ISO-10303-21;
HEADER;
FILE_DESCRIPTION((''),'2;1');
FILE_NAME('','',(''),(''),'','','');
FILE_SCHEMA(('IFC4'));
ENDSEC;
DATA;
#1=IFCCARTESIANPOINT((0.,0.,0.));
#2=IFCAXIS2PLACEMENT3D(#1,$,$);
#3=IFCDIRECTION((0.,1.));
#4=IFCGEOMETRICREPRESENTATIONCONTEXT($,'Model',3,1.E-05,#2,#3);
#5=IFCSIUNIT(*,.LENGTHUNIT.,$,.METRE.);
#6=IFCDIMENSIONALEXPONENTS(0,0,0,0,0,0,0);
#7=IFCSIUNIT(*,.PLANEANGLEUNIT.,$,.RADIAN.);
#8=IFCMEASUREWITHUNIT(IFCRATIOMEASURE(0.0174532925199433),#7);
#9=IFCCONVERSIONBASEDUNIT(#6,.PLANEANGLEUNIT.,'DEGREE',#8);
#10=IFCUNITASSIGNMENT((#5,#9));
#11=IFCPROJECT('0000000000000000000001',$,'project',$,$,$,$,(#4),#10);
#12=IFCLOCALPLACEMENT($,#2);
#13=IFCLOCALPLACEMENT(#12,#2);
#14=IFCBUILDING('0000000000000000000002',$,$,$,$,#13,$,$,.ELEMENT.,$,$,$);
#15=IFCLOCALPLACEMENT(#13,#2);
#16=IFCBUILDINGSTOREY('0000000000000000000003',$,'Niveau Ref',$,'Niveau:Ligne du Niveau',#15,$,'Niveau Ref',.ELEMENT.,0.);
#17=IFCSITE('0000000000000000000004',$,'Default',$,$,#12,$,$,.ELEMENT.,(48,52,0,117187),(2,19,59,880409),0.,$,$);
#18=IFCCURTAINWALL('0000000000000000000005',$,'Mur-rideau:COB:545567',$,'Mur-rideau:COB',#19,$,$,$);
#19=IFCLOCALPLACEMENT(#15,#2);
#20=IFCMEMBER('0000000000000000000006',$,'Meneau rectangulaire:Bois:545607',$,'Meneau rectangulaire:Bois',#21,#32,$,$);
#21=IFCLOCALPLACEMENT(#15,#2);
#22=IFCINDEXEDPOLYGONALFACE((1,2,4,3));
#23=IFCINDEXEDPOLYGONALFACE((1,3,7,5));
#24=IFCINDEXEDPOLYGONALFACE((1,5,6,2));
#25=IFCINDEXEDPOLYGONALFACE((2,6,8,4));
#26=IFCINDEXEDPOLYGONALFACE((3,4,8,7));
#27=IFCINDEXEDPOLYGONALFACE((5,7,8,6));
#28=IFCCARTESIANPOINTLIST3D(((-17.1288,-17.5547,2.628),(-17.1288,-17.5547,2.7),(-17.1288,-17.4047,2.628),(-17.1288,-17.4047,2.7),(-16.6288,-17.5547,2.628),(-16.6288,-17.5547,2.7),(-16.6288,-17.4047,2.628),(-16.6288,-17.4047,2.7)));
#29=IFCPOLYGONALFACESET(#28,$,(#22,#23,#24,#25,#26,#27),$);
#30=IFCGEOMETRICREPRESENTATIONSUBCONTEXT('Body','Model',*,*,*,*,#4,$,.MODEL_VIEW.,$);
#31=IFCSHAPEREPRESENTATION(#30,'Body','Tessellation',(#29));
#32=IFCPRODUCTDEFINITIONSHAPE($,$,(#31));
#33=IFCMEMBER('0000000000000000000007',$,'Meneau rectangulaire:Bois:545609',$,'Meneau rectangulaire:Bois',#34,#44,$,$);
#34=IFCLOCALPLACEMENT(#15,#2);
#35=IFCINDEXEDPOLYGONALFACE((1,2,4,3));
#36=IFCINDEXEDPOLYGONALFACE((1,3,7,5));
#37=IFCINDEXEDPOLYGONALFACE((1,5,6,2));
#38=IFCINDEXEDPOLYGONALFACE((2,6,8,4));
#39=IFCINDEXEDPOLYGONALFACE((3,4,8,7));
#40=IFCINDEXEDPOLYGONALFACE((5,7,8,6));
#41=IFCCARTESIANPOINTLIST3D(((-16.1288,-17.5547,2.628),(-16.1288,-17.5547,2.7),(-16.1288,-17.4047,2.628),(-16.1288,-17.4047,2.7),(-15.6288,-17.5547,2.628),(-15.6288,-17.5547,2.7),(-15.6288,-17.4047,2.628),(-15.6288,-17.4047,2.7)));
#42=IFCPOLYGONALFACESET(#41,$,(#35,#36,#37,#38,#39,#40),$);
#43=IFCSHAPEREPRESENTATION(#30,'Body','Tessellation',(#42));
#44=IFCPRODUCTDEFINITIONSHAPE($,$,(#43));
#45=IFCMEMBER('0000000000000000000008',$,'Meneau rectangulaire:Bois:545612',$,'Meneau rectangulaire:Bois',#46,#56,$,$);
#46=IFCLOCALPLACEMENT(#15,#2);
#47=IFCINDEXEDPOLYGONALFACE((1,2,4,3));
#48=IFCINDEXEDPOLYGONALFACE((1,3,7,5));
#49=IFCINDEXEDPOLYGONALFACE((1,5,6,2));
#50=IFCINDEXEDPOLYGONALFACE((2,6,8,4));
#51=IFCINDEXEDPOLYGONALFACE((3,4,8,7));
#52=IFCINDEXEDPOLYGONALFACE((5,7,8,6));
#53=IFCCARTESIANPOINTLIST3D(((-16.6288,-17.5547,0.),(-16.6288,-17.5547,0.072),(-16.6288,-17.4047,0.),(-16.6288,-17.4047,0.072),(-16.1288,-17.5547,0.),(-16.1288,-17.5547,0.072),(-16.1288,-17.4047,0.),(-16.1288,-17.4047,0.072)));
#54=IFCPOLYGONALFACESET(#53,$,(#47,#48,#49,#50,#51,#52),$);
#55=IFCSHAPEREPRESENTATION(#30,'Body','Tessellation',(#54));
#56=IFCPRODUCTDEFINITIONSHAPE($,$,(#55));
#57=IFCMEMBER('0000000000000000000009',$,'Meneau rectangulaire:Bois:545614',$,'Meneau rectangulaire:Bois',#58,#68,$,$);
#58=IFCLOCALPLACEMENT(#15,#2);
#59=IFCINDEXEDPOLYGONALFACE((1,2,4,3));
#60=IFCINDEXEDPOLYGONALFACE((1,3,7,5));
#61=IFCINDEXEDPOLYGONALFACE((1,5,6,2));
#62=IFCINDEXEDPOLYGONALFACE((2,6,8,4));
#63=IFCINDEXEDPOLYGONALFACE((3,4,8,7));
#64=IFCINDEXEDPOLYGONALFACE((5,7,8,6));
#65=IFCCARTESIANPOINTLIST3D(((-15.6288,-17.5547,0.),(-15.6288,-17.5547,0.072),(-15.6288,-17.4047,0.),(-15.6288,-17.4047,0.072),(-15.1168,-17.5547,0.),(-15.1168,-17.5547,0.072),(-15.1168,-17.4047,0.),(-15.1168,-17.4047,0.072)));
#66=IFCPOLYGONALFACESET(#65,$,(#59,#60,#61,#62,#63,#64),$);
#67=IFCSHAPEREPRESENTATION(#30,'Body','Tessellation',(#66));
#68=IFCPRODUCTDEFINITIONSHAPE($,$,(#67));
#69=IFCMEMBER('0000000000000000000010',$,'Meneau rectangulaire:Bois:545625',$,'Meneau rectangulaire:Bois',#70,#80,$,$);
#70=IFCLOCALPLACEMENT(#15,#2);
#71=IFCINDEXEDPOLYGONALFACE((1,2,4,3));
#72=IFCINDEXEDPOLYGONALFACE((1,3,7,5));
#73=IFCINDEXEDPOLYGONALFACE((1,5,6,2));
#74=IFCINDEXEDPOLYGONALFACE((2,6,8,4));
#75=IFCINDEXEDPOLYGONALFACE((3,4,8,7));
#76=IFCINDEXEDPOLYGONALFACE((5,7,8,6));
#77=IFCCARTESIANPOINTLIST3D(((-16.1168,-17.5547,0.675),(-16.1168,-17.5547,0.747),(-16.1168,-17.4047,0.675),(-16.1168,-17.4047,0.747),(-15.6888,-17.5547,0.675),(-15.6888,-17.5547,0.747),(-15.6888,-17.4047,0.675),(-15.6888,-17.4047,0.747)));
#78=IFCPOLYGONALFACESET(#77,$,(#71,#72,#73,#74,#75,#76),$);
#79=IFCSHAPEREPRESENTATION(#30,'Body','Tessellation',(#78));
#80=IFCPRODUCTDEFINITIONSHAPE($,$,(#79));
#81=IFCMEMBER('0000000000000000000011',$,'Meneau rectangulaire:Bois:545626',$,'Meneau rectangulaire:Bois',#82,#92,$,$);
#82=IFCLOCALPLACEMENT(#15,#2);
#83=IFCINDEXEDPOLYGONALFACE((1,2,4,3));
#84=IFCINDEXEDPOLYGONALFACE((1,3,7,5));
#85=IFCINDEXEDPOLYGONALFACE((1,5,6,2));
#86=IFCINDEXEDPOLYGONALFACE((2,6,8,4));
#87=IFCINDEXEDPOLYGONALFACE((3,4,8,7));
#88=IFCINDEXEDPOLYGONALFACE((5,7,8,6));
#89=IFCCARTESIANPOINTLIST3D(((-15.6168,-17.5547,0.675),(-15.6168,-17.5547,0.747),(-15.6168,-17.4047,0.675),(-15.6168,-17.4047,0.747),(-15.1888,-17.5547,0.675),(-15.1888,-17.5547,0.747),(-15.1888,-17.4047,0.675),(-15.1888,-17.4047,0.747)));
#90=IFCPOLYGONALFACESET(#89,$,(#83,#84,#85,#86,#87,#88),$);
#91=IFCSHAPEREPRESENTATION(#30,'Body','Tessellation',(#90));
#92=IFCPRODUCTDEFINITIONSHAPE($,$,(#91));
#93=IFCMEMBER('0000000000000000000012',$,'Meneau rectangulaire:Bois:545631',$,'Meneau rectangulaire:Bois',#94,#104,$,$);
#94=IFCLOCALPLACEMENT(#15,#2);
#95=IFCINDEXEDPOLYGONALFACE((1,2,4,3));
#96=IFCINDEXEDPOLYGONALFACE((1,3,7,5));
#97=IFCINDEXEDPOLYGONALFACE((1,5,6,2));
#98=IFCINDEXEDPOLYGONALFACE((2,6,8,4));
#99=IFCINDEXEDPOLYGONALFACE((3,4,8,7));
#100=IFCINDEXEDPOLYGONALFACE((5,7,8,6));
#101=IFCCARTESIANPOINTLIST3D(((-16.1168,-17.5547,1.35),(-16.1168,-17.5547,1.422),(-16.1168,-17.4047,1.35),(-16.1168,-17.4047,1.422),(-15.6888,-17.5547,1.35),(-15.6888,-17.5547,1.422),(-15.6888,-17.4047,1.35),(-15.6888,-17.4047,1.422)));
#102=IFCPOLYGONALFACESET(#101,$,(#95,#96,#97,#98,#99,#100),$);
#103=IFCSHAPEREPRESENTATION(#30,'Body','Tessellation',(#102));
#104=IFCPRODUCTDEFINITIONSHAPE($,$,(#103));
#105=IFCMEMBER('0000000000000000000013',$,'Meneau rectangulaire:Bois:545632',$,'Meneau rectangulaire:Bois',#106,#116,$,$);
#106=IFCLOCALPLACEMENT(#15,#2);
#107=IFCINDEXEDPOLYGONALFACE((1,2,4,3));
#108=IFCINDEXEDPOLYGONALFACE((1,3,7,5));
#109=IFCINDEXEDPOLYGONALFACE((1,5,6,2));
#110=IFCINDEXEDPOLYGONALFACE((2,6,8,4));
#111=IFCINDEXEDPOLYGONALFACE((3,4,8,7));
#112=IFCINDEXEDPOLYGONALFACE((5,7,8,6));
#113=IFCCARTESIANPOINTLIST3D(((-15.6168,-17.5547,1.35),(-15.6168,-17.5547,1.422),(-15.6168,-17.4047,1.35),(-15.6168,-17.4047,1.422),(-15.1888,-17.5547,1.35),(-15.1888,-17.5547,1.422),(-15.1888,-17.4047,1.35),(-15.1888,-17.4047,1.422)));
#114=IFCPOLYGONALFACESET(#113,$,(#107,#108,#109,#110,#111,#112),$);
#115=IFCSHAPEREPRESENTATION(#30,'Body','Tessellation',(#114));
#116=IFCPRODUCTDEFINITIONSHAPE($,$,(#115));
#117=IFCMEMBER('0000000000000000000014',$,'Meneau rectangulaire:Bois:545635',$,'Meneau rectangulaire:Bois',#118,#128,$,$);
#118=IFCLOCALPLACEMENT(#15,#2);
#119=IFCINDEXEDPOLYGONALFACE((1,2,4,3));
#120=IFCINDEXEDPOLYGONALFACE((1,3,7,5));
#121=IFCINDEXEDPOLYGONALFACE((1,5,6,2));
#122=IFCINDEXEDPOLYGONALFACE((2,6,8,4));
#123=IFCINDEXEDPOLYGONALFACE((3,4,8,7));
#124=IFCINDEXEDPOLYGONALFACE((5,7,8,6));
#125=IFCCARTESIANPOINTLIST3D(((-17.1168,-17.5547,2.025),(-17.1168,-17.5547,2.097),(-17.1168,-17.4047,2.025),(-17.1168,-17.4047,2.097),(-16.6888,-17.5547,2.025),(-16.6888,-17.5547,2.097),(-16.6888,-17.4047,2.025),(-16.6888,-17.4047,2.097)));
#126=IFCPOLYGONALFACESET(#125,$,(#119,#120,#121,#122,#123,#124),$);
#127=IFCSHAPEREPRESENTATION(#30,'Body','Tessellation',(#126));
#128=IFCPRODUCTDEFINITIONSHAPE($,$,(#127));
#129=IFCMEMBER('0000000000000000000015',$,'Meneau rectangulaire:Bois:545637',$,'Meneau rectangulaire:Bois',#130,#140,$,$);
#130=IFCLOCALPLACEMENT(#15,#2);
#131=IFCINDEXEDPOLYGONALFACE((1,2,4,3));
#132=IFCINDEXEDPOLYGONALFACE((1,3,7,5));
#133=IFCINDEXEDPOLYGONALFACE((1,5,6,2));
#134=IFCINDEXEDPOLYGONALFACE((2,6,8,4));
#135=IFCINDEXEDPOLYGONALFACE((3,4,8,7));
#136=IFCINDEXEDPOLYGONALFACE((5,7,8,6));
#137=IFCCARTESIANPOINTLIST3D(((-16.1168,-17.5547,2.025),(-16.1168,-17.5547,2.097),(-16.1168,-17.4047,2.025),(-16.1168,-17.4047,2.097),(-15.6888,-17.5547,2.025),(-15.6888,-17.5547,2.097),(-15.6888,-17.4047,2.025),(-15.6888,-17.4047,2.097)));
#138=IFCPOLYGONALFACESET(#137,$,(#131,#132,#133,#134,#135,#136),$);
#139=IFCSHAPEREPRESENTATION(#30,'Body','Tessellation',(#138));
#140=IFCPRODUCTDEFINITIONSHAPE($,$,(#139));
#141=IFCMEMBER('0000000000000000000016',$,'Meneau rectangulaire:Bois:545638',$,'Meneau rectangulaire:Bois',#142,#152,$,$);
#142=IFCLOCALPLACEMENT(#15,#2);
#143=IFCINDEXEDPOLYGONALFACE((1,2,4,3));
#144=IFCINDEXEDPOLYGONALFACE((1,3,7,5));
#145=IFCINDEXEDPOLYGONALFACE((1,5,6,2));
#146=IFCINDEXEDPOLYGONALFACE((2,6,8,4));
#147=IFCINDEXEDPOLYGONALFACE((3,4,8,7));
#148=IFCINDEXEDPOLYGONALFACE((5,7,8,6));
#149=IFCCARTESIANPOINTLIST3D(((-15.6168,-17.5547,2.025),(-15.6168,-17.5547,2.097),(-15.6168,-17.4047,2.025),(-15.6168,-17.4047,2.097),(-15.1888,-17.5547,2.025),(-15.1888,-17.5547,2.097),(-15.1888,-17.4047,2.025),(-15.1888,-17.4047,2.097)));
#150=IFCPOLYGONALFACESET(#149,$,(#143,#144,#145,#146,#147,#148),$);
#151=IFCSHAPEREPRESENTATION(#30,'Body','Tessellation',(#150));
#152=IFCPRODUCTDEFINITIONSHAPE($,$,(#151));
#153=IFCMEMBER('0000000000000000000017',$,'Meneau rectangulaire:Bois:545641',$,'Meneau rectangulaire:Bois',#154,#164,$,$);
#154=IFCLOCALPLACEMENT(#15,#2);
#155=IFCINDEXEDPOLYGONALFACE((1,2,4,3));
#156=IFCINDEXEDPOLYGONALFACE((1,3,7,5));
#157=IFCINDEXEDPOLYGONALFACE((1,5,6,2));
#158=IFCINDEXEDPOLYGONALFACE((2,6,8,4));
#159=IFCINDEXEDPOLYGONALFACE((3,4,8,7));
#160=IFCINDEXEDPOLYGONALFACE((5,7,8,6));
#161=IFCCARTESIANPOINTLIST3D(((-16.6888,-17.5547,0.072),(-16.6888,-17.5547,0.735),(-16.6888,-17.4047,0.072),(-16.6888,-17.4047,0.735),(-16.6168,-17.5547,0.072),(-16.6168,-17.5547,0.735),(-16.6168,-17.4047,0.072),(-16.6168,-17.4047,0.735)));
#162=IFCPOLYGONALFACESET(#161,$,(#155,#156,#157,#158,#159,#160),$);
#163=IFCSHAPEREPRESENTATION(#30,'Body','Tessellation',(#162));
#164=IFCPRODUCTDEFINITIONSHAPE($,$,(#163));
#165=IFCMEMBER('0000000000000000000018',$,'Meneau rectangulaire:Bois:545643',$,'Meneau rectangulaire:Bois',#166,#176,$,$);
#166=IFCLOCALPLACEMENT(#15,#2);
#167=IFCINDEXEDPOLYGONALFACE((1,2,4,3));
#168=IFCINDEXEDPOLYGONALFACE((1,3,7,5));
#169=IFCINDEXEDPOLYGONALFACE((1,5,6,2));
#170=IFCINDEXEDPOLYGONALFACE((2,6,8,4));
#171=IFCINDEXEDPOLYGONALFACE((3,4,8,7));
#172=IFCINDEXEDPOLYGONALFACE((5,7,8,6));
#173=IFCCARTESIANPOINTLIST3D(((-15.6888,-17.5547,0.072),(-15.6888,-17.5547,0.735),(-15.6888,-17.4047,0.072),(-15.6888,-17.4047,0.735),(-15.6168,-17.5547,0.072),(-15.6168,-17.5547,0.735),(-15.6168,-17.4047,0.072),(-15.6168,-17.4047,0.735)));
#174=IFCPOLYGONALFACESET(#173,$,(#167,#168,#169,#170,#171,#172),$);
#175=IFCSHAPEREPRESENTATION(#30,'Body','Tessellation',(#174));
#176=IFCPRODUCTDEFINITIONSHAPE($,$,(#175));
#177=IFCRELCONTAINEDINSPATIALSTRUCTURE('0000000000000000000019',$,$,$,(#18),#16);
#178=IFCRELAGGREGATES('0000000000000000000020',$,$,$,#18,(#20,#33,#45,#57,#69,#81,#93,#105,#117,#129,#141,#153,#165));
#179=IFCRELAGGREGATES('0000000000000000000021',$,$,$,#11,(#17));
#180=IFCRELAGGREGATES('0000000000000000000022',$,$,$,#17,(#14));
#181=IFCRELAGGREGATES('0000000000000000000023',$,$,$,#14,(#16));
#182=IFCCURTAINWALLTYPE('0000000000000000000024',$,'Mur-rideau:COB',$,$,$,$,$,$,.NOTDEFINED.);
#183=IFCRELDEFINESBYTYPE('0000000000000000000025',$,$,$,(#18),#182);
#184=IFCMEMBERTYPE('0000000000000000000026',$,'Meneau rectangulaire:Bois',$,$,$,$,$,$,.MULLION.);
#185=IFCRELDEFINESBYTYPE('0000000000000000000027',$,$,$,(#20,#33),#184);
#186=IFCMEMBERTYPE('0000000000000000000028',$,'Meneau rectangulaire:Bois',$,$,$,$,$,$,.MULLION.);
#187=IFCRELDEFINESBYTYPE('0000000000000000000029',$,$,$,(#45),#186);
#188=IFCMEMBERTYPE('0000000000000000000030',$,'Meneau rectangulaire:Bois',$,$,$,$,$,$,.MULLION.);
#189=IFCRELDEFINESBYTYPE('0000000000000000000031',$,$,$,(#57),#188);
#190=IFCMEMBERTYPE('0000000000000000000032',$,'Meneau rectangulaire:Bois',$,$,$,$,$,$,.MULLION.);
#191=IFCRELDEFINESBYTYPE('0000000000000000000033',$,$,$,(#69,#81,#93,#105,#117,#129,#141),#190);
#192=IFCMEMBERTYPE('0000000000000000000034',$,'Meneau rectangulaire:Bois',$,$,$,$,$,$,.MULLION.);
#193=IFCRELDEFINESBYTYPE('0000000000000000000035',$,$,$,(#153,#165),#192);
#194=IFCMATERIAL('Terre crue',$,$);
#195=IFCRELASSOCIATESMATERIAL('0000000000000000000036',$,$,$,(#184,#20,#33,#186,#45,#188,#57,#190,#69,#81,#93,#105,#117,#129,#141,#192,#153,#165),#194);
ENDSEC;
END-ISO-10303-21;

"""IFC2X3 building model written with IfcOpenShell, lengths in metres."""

from ifc_helpers import new_model, entity, si_unit, converted_unit, direction, frame, origin, origin_2d_with_axis, place, context, subcontext, project, spatial, rectangle, extrude, source, transform, mapped, material, type_object, type_shapes, element, aggregate, save


model = new_model("IFC2X3")

# Units and contexts
model_context = context("Model", 3, precision=1e-05, world=origin(), true_north=direction((0.0, 1.0)))
body_context = subcontext(model_context, "Body", "Model", "MODEL_VIEW")
ifc_project = project(units=[si_unit("LENGTHUNIT", "METRE"), converted_unit("PLANEANGLEUNIT", "DEGREE", entity("IfcRatioMeasure", 0.0174532925199433), si_unit("PLANEANGLEUNIT", "RADIAN"), dimensions=[0, 0, 0, 0, 0, 0, 0])], contexts=[model_context])

# Site, building, storey
site_placement = place(None, origin())
site = spatial("IfcSite", under=ifc_project, at=site_placement, Name="Default", CompositionType="ELEMENT", RefLatitude=(48, 52, 0, 117187), RefLongitude=(2, 19, 59, 880409), RefElevation=0.0)
building_placement = place(site_placement, origin())
building = spatial("IfcBuilding", under=site, at=building_placement, CompositionType="ELEMENT")
storey_placement = place(building_placement, origin())
storey = spatial("IfcBuildingStorey", under=building, at=storey_placement, Name="Niveau Ref", ObjectType="Niveau:Ligne du Niveau", LongName="Niveau Ref", CompositionType="ELEMENT", Elevation=0.0)

# Curtain wall, members
curtain_wall_type_1 = type_object("IfcCurtainWallType", Name="Mur-rideau:COB", PredefinedType="NOTDEFINED")
curtain_wall_1_placement = place(storey_placement, origin())
curtain_wall_1 = element("IfcCurtainWall", 1, at=curtain_wall_1_placement, inside=storey, type_object=curtain_wall_type_1, Name="Mur-rideau:COB:545567", ObjectType="Mur-rideau:COB")
ifc_material_1 = material(Name="Terre crue")
member_type_1 = type_object("IfcMemberType", Name="Meneau rectangulaire:Bois", PredefinedType="MULLION", material=ifc_material_1)
shared_shape_1 = source(origin(), body_context, "Body", "SweptSolid", [
    extrude(rectangle(XDim=0.15, YDim=0.072, at=origin_2d_with_axis()), frame((-0.036, 0.0, -0.5), z_axis=(0.0, 0.0, 1.0), x_axis=(0.0, -1.0, 0.0)), (0.0, 0.0, 1.0), 0.5),
])
type_shapes(member_type_1, [shared_shape_1])
member_1_placement = place(storey_placement, frame((-16.6288, -17.4797, 2.7), z_axis=(1.0, 0.0, 0.0), x_axis=(0.0, 0.0, 1.0)))
member_1 = element("IfcMember", 2, at=member_1_placement, type_object=member_type_1, material=ifc_material_1, Name="Meneau rectangulaire:Bois:545607", ObjectType="Meneau rectangulaire:Bois", context=body_context, shape_type="MappedRepresentation", body=[
    mapped(shared_shape_1, transform((0.0, 0.0, 0.0), scale=1.0)),
])
member_2_placement = place(storey_placement, frame((-15.6288, -17.4797, 2.7), z_axis=(1.0, 0.0, 0.0), x_axis=(0.0, 0.0, 1.0)))
member_2 = element("IfcMember", 3, at=member_2_placement, type_object=member_type_1, material=ifc_material_1, Name="Meneau rectangulaire:Bois:545609", ObjectType="Meneau rectangulaire:Bois", context=body_context, shape_type="MappedRepresentation", body=[
    mapped(shared_shape_1, transform((0.0, 0.0, 0.0), scale=1.0)),
])
member_type_2 = type_object("IfcMemberType", Name="Meneau rectangulaire:Bois", PredefinedType="MULLION", material=ifc_material_1)
shared_shape_2 = source(origin(), body_context, "Body", "SweptSolid", [
    extrude(rectangle(XDim=0.15, YDim=0.072, at=origin_2d_with_axis()), frame((-0.036, 0.0, -0.5), z_axis=(0.0, 0.0, 1.0), x_axis=(0.0, -1.0, 0.0)), (0.0, 0.0, 1.0), 0.5),
])
type_shapes(member_type_2, [shared_shape_2])
member_3_placement = place(storey_placement, frame((-16.6288, -17.4797, 0.0), z_axis=(-1.0, 0.0, 0.0), x_axis=(0.0, 0.0, -1.0)))
member_3 = element("IfcMember", 4, at=member_3_placement, type_object=member_type_2, material=ifc_material_1, Name="Meneau rectangulaire:Bois:545612", ObjectType="Meneau rectangulaire:Bois", context=body_context, shape_type="MappedRepresentation", body=[
    mapped(shared_shape_2, transform((0.0, 0.0, 0.0), scale=1.0)),
])
member_type_3 = type_object("IfcMemberType", Name="Meneau rectangulaire:Bois", PredefinedType="MULLION", material=ifc_material_1)
shared_shape_3 = source(origin(), body_context, "Body", "SweptSolid", [
    extrude(rectangle(XDim=0.15, YDim=0.072, at=origin_2d_with_axis()), frame((-0.036, 0.0, -0.512), z_axis=(0.0, 0.0, 1.0), x_axis=(0.0, -1.0, 0.0)), (0.0, 0.0, 1.0), 0.512),
])
type_shapes(member_type_3, [shared_shape_3])
member_4_placement = place(storey_placement, frame((-15.6288, -17.4797, 0.0), z_axis=(-1.0, 0.0, 0.0), x_axis=(0.0, 0.0, -1.0)))
member_4 = element("IfcMember", 5, at=member_4_placement, type_object=member_type_3, material=ifc_material_1, Name="Meneau rectangulaire:Bois:545614", ObjectType="Meneau rectangulaire:Bois", context=body_context, shape_type="MappedRepresentation", body=[
    mapped(shared_shape_3, transform((0.0, 0.0, 0.0), scale=1.0)),
])
member_type_4 = type_object("IfcMemberType", Name="Meneau rectangulaire:Bois", PredefinedType="MULLION", material=ifc_material_1)
shared_shape_4 = source(origin(), body_context, "Body", "SweptSolid", [
    extrude(rectangle(XDim=0.15, YDim=0.072, at=origin_2d_with_axis()), frame((-0.024, 0.0, -0.428), z_axis=(0.0, 0.0, 1.0), x_axis=(0.0, -1.0, 0.0)), (0.0, 0.0, 1.0), 0.428),
])
type_shapes(member_type_4, [shared_shape_4])
member_5_placement = place(storey_placement, frame((-15.6888, -17.4797, 0.735), z_axis=(1.0, 0.0, 0.0), x_axis=(0.0, 0.0, 1.0)))
member_5 = element("IfcMember", 6, at=member_5_placement, type_object=member_type_4, material=ifc_material_1, Name="Meneau rectangulaire:Bois:545625", ObjectType="Meneau rectangulaire:Bois", context=body_context, shape_type="MappedRepresentation", body=[
    mapped(shared_shape_4, transform((0.0, 0.0, 0.0), scale=1.0)),
])
member_6_placement = place(storey_placement, frame((-15.1888, -17.4797, 0.735), z_axis=(1.0, 0.0, 0.0), x_axis=(0.0, 0.0, 1.0)))
member_6 = element("IfcMember", 7, at=member_6_placement, type_object=member_type_4, material=ifc_material_1, Name="Meneau rectangulaire:Bois:545626", ObjectType="Meneau rectangulaire:Bois", context=body_context, shape_type="MappedRepresentation", body=[
    mapped(shared_shape_4, transform((0.0, 0.0, 0.0), scale=1.0)),
])
member_7_placement = place(storey_placement, frame((-15.6888, -17.4797, 1.41), z_axis=(1.0, 0.0, 0.0), x_axis=(0.0, 0.0, 1.0)))
member_7 = element("IfcMember", 8, at=member_7_placement, type_object=member_type_4, material=ifc_material_1, Name="Meneau rectangulaire:Bois:545631", ObjectType="Meneau rectangulaire:Bois", context=body_context, shape_type="MappedRepresentation", body=[
    mapped(shared_shape_4, transform((0.0, 0.0, 0.0), scale=1.0)),
])
member_8_placement = place(storey_placement, frame((-15.1888, -17.4797, 1.41), z_axis=(1.0, 0.0, 0.0), x_axis=(0.0, 0.0, 1.0)))
member_8 = element("IfcMember", 9, at=member_8_placement, type_object=member_type_4, material=ifc_material_1, Name="Meneau rectangulaire:Bois:545632", ObjectType="Meneau rectangulaire:Bois", context=body_context, shape_type="MappedRepresentation", body=[
    mapped(shared_shape_4, transform((0.0, 0.0, 0.0), scale=1.0)),
])
member_9_placement = place(storey_placement, frame((-16.6888, -17.4797, 2.085), z_axis=(1.0, 0.0, 0.0), x_axis=(0.0, 0.0, 1.0)))
member_9 = element("IfcMember", 10, at=member_9_placement, type_object=member_type_4, material=ifc_material_1, Name="Meneau rectangulaire:Bois:545635", ObjectType="Meneau rectangulaire:Bois", context=body_context, shape_type="MappedRepresentation", body=[
    mapped(shared_shape_4, transform((0.0, 0.0, 0.0), scale=1.0)),
])
member_10_placement = place(storey_placement, frame((-15.6888, -17.4797, 2.085), z_axis=(1.0, 0.0, 0.0), x_axis=(0.0, 0.0, 1.0)))
member_10 = element("IfcMember", 11, at=member_10_placement, type_object=member_type_4, material=ifc_material_1, Name="Meneau rectangulaire:Bois:545637", ObjectType="Meneau rectangulaire:Bois", context=body_context, shape_type="MappedRepresentation", body=[
    mapped(shared_shape_4, transform((0.0, 0.0, 0.0), scale=1.0)),
])
member_11_placement = place(storey_placement, frame((-15.1888, -17.4797, 2.085), z_axis=(1.0, 0.0, 0.0), x_axis=(0.0, 0.0, 1.0)))
member_11 = element("IfcMember", 12, at=member_11_placement, type_object=member_type_4, material=ifc_material_1, Name="Meneau rectangulaire:Bois:545638", ObjectType="Meneau rectangulaire:Bois", context=body_context, shape_type="MappedRepresentation", body=[
    mapped(shared_shape_4, transform((0.0, 0.0, 0.0), scale=1.0)),
])
member_type_5 = type_object("IfcMemberType", Name="Meneau rectangulaire:Bois", PredefinedType="MULLION", material=ifc_material_1)
shared_shape_5 = source(origin(), body_context, "Body", "SweptSolid", [
    extrude(rectangle(XDim=0.15, YDim=0.072, at=origin_2d_with_axis()), frame((-0.024, 0.0, -0.663), z_axis=(0.0, 0.0, 1.0), x_axis=(0.0, -1.0, 0.0)), (0.0, 0.0, 1.0), 0.663),
])
type_shapes(member_type_5, [shared_shape_5])
member_12_placement = place(storey_placement, frame((-16.6288, -17.4797, 0.072), z_axis=(0.0, 0.0, -1.0), x_axis=(1.0, 0.0, 0.0)))
member_12 = element("IfcMember", 13, at=member_12_placement, type_object=member_type_5, material=ifc_material_1, Name="Meneau rectangulaire:Bois:545641", ObjectType="Meneau rectangulaire:Bois", context=body_context, shape_type="MappedRepresentation", body=[
    mapped(shared_shape_5, transform((0.0, 0.0, 0.0), scale=1.0)),
])
member_13_placement = place(storey_placement, frame((-15.6288, -17.4797, 0.072), z_axis=(0.0, 0.0, -1.0), x_axis=(1.0, 0.0, 0.0)))
member_13 = element("IfcMember", 14, at=member_13_placement, type_object=member_type_5, material=ifc_material_1, Name="Meneau rectangulaire:Bois:545643", ObjectType="Meneau rectangulaire:Bois", context=body_context, shape_type="MappedRepresentation", body=[
    mapped(shared_shape_5, transform((0.0, 0.0, 0.0), scale=1.0)),
])
aggregate(curtain_wall_1, [member_1, member_2, member_3, member_4, member_5, member_6, member_7, member_8, member_9, member_10, member_11, member_12, member_13])

save(model, "model.ifc")
